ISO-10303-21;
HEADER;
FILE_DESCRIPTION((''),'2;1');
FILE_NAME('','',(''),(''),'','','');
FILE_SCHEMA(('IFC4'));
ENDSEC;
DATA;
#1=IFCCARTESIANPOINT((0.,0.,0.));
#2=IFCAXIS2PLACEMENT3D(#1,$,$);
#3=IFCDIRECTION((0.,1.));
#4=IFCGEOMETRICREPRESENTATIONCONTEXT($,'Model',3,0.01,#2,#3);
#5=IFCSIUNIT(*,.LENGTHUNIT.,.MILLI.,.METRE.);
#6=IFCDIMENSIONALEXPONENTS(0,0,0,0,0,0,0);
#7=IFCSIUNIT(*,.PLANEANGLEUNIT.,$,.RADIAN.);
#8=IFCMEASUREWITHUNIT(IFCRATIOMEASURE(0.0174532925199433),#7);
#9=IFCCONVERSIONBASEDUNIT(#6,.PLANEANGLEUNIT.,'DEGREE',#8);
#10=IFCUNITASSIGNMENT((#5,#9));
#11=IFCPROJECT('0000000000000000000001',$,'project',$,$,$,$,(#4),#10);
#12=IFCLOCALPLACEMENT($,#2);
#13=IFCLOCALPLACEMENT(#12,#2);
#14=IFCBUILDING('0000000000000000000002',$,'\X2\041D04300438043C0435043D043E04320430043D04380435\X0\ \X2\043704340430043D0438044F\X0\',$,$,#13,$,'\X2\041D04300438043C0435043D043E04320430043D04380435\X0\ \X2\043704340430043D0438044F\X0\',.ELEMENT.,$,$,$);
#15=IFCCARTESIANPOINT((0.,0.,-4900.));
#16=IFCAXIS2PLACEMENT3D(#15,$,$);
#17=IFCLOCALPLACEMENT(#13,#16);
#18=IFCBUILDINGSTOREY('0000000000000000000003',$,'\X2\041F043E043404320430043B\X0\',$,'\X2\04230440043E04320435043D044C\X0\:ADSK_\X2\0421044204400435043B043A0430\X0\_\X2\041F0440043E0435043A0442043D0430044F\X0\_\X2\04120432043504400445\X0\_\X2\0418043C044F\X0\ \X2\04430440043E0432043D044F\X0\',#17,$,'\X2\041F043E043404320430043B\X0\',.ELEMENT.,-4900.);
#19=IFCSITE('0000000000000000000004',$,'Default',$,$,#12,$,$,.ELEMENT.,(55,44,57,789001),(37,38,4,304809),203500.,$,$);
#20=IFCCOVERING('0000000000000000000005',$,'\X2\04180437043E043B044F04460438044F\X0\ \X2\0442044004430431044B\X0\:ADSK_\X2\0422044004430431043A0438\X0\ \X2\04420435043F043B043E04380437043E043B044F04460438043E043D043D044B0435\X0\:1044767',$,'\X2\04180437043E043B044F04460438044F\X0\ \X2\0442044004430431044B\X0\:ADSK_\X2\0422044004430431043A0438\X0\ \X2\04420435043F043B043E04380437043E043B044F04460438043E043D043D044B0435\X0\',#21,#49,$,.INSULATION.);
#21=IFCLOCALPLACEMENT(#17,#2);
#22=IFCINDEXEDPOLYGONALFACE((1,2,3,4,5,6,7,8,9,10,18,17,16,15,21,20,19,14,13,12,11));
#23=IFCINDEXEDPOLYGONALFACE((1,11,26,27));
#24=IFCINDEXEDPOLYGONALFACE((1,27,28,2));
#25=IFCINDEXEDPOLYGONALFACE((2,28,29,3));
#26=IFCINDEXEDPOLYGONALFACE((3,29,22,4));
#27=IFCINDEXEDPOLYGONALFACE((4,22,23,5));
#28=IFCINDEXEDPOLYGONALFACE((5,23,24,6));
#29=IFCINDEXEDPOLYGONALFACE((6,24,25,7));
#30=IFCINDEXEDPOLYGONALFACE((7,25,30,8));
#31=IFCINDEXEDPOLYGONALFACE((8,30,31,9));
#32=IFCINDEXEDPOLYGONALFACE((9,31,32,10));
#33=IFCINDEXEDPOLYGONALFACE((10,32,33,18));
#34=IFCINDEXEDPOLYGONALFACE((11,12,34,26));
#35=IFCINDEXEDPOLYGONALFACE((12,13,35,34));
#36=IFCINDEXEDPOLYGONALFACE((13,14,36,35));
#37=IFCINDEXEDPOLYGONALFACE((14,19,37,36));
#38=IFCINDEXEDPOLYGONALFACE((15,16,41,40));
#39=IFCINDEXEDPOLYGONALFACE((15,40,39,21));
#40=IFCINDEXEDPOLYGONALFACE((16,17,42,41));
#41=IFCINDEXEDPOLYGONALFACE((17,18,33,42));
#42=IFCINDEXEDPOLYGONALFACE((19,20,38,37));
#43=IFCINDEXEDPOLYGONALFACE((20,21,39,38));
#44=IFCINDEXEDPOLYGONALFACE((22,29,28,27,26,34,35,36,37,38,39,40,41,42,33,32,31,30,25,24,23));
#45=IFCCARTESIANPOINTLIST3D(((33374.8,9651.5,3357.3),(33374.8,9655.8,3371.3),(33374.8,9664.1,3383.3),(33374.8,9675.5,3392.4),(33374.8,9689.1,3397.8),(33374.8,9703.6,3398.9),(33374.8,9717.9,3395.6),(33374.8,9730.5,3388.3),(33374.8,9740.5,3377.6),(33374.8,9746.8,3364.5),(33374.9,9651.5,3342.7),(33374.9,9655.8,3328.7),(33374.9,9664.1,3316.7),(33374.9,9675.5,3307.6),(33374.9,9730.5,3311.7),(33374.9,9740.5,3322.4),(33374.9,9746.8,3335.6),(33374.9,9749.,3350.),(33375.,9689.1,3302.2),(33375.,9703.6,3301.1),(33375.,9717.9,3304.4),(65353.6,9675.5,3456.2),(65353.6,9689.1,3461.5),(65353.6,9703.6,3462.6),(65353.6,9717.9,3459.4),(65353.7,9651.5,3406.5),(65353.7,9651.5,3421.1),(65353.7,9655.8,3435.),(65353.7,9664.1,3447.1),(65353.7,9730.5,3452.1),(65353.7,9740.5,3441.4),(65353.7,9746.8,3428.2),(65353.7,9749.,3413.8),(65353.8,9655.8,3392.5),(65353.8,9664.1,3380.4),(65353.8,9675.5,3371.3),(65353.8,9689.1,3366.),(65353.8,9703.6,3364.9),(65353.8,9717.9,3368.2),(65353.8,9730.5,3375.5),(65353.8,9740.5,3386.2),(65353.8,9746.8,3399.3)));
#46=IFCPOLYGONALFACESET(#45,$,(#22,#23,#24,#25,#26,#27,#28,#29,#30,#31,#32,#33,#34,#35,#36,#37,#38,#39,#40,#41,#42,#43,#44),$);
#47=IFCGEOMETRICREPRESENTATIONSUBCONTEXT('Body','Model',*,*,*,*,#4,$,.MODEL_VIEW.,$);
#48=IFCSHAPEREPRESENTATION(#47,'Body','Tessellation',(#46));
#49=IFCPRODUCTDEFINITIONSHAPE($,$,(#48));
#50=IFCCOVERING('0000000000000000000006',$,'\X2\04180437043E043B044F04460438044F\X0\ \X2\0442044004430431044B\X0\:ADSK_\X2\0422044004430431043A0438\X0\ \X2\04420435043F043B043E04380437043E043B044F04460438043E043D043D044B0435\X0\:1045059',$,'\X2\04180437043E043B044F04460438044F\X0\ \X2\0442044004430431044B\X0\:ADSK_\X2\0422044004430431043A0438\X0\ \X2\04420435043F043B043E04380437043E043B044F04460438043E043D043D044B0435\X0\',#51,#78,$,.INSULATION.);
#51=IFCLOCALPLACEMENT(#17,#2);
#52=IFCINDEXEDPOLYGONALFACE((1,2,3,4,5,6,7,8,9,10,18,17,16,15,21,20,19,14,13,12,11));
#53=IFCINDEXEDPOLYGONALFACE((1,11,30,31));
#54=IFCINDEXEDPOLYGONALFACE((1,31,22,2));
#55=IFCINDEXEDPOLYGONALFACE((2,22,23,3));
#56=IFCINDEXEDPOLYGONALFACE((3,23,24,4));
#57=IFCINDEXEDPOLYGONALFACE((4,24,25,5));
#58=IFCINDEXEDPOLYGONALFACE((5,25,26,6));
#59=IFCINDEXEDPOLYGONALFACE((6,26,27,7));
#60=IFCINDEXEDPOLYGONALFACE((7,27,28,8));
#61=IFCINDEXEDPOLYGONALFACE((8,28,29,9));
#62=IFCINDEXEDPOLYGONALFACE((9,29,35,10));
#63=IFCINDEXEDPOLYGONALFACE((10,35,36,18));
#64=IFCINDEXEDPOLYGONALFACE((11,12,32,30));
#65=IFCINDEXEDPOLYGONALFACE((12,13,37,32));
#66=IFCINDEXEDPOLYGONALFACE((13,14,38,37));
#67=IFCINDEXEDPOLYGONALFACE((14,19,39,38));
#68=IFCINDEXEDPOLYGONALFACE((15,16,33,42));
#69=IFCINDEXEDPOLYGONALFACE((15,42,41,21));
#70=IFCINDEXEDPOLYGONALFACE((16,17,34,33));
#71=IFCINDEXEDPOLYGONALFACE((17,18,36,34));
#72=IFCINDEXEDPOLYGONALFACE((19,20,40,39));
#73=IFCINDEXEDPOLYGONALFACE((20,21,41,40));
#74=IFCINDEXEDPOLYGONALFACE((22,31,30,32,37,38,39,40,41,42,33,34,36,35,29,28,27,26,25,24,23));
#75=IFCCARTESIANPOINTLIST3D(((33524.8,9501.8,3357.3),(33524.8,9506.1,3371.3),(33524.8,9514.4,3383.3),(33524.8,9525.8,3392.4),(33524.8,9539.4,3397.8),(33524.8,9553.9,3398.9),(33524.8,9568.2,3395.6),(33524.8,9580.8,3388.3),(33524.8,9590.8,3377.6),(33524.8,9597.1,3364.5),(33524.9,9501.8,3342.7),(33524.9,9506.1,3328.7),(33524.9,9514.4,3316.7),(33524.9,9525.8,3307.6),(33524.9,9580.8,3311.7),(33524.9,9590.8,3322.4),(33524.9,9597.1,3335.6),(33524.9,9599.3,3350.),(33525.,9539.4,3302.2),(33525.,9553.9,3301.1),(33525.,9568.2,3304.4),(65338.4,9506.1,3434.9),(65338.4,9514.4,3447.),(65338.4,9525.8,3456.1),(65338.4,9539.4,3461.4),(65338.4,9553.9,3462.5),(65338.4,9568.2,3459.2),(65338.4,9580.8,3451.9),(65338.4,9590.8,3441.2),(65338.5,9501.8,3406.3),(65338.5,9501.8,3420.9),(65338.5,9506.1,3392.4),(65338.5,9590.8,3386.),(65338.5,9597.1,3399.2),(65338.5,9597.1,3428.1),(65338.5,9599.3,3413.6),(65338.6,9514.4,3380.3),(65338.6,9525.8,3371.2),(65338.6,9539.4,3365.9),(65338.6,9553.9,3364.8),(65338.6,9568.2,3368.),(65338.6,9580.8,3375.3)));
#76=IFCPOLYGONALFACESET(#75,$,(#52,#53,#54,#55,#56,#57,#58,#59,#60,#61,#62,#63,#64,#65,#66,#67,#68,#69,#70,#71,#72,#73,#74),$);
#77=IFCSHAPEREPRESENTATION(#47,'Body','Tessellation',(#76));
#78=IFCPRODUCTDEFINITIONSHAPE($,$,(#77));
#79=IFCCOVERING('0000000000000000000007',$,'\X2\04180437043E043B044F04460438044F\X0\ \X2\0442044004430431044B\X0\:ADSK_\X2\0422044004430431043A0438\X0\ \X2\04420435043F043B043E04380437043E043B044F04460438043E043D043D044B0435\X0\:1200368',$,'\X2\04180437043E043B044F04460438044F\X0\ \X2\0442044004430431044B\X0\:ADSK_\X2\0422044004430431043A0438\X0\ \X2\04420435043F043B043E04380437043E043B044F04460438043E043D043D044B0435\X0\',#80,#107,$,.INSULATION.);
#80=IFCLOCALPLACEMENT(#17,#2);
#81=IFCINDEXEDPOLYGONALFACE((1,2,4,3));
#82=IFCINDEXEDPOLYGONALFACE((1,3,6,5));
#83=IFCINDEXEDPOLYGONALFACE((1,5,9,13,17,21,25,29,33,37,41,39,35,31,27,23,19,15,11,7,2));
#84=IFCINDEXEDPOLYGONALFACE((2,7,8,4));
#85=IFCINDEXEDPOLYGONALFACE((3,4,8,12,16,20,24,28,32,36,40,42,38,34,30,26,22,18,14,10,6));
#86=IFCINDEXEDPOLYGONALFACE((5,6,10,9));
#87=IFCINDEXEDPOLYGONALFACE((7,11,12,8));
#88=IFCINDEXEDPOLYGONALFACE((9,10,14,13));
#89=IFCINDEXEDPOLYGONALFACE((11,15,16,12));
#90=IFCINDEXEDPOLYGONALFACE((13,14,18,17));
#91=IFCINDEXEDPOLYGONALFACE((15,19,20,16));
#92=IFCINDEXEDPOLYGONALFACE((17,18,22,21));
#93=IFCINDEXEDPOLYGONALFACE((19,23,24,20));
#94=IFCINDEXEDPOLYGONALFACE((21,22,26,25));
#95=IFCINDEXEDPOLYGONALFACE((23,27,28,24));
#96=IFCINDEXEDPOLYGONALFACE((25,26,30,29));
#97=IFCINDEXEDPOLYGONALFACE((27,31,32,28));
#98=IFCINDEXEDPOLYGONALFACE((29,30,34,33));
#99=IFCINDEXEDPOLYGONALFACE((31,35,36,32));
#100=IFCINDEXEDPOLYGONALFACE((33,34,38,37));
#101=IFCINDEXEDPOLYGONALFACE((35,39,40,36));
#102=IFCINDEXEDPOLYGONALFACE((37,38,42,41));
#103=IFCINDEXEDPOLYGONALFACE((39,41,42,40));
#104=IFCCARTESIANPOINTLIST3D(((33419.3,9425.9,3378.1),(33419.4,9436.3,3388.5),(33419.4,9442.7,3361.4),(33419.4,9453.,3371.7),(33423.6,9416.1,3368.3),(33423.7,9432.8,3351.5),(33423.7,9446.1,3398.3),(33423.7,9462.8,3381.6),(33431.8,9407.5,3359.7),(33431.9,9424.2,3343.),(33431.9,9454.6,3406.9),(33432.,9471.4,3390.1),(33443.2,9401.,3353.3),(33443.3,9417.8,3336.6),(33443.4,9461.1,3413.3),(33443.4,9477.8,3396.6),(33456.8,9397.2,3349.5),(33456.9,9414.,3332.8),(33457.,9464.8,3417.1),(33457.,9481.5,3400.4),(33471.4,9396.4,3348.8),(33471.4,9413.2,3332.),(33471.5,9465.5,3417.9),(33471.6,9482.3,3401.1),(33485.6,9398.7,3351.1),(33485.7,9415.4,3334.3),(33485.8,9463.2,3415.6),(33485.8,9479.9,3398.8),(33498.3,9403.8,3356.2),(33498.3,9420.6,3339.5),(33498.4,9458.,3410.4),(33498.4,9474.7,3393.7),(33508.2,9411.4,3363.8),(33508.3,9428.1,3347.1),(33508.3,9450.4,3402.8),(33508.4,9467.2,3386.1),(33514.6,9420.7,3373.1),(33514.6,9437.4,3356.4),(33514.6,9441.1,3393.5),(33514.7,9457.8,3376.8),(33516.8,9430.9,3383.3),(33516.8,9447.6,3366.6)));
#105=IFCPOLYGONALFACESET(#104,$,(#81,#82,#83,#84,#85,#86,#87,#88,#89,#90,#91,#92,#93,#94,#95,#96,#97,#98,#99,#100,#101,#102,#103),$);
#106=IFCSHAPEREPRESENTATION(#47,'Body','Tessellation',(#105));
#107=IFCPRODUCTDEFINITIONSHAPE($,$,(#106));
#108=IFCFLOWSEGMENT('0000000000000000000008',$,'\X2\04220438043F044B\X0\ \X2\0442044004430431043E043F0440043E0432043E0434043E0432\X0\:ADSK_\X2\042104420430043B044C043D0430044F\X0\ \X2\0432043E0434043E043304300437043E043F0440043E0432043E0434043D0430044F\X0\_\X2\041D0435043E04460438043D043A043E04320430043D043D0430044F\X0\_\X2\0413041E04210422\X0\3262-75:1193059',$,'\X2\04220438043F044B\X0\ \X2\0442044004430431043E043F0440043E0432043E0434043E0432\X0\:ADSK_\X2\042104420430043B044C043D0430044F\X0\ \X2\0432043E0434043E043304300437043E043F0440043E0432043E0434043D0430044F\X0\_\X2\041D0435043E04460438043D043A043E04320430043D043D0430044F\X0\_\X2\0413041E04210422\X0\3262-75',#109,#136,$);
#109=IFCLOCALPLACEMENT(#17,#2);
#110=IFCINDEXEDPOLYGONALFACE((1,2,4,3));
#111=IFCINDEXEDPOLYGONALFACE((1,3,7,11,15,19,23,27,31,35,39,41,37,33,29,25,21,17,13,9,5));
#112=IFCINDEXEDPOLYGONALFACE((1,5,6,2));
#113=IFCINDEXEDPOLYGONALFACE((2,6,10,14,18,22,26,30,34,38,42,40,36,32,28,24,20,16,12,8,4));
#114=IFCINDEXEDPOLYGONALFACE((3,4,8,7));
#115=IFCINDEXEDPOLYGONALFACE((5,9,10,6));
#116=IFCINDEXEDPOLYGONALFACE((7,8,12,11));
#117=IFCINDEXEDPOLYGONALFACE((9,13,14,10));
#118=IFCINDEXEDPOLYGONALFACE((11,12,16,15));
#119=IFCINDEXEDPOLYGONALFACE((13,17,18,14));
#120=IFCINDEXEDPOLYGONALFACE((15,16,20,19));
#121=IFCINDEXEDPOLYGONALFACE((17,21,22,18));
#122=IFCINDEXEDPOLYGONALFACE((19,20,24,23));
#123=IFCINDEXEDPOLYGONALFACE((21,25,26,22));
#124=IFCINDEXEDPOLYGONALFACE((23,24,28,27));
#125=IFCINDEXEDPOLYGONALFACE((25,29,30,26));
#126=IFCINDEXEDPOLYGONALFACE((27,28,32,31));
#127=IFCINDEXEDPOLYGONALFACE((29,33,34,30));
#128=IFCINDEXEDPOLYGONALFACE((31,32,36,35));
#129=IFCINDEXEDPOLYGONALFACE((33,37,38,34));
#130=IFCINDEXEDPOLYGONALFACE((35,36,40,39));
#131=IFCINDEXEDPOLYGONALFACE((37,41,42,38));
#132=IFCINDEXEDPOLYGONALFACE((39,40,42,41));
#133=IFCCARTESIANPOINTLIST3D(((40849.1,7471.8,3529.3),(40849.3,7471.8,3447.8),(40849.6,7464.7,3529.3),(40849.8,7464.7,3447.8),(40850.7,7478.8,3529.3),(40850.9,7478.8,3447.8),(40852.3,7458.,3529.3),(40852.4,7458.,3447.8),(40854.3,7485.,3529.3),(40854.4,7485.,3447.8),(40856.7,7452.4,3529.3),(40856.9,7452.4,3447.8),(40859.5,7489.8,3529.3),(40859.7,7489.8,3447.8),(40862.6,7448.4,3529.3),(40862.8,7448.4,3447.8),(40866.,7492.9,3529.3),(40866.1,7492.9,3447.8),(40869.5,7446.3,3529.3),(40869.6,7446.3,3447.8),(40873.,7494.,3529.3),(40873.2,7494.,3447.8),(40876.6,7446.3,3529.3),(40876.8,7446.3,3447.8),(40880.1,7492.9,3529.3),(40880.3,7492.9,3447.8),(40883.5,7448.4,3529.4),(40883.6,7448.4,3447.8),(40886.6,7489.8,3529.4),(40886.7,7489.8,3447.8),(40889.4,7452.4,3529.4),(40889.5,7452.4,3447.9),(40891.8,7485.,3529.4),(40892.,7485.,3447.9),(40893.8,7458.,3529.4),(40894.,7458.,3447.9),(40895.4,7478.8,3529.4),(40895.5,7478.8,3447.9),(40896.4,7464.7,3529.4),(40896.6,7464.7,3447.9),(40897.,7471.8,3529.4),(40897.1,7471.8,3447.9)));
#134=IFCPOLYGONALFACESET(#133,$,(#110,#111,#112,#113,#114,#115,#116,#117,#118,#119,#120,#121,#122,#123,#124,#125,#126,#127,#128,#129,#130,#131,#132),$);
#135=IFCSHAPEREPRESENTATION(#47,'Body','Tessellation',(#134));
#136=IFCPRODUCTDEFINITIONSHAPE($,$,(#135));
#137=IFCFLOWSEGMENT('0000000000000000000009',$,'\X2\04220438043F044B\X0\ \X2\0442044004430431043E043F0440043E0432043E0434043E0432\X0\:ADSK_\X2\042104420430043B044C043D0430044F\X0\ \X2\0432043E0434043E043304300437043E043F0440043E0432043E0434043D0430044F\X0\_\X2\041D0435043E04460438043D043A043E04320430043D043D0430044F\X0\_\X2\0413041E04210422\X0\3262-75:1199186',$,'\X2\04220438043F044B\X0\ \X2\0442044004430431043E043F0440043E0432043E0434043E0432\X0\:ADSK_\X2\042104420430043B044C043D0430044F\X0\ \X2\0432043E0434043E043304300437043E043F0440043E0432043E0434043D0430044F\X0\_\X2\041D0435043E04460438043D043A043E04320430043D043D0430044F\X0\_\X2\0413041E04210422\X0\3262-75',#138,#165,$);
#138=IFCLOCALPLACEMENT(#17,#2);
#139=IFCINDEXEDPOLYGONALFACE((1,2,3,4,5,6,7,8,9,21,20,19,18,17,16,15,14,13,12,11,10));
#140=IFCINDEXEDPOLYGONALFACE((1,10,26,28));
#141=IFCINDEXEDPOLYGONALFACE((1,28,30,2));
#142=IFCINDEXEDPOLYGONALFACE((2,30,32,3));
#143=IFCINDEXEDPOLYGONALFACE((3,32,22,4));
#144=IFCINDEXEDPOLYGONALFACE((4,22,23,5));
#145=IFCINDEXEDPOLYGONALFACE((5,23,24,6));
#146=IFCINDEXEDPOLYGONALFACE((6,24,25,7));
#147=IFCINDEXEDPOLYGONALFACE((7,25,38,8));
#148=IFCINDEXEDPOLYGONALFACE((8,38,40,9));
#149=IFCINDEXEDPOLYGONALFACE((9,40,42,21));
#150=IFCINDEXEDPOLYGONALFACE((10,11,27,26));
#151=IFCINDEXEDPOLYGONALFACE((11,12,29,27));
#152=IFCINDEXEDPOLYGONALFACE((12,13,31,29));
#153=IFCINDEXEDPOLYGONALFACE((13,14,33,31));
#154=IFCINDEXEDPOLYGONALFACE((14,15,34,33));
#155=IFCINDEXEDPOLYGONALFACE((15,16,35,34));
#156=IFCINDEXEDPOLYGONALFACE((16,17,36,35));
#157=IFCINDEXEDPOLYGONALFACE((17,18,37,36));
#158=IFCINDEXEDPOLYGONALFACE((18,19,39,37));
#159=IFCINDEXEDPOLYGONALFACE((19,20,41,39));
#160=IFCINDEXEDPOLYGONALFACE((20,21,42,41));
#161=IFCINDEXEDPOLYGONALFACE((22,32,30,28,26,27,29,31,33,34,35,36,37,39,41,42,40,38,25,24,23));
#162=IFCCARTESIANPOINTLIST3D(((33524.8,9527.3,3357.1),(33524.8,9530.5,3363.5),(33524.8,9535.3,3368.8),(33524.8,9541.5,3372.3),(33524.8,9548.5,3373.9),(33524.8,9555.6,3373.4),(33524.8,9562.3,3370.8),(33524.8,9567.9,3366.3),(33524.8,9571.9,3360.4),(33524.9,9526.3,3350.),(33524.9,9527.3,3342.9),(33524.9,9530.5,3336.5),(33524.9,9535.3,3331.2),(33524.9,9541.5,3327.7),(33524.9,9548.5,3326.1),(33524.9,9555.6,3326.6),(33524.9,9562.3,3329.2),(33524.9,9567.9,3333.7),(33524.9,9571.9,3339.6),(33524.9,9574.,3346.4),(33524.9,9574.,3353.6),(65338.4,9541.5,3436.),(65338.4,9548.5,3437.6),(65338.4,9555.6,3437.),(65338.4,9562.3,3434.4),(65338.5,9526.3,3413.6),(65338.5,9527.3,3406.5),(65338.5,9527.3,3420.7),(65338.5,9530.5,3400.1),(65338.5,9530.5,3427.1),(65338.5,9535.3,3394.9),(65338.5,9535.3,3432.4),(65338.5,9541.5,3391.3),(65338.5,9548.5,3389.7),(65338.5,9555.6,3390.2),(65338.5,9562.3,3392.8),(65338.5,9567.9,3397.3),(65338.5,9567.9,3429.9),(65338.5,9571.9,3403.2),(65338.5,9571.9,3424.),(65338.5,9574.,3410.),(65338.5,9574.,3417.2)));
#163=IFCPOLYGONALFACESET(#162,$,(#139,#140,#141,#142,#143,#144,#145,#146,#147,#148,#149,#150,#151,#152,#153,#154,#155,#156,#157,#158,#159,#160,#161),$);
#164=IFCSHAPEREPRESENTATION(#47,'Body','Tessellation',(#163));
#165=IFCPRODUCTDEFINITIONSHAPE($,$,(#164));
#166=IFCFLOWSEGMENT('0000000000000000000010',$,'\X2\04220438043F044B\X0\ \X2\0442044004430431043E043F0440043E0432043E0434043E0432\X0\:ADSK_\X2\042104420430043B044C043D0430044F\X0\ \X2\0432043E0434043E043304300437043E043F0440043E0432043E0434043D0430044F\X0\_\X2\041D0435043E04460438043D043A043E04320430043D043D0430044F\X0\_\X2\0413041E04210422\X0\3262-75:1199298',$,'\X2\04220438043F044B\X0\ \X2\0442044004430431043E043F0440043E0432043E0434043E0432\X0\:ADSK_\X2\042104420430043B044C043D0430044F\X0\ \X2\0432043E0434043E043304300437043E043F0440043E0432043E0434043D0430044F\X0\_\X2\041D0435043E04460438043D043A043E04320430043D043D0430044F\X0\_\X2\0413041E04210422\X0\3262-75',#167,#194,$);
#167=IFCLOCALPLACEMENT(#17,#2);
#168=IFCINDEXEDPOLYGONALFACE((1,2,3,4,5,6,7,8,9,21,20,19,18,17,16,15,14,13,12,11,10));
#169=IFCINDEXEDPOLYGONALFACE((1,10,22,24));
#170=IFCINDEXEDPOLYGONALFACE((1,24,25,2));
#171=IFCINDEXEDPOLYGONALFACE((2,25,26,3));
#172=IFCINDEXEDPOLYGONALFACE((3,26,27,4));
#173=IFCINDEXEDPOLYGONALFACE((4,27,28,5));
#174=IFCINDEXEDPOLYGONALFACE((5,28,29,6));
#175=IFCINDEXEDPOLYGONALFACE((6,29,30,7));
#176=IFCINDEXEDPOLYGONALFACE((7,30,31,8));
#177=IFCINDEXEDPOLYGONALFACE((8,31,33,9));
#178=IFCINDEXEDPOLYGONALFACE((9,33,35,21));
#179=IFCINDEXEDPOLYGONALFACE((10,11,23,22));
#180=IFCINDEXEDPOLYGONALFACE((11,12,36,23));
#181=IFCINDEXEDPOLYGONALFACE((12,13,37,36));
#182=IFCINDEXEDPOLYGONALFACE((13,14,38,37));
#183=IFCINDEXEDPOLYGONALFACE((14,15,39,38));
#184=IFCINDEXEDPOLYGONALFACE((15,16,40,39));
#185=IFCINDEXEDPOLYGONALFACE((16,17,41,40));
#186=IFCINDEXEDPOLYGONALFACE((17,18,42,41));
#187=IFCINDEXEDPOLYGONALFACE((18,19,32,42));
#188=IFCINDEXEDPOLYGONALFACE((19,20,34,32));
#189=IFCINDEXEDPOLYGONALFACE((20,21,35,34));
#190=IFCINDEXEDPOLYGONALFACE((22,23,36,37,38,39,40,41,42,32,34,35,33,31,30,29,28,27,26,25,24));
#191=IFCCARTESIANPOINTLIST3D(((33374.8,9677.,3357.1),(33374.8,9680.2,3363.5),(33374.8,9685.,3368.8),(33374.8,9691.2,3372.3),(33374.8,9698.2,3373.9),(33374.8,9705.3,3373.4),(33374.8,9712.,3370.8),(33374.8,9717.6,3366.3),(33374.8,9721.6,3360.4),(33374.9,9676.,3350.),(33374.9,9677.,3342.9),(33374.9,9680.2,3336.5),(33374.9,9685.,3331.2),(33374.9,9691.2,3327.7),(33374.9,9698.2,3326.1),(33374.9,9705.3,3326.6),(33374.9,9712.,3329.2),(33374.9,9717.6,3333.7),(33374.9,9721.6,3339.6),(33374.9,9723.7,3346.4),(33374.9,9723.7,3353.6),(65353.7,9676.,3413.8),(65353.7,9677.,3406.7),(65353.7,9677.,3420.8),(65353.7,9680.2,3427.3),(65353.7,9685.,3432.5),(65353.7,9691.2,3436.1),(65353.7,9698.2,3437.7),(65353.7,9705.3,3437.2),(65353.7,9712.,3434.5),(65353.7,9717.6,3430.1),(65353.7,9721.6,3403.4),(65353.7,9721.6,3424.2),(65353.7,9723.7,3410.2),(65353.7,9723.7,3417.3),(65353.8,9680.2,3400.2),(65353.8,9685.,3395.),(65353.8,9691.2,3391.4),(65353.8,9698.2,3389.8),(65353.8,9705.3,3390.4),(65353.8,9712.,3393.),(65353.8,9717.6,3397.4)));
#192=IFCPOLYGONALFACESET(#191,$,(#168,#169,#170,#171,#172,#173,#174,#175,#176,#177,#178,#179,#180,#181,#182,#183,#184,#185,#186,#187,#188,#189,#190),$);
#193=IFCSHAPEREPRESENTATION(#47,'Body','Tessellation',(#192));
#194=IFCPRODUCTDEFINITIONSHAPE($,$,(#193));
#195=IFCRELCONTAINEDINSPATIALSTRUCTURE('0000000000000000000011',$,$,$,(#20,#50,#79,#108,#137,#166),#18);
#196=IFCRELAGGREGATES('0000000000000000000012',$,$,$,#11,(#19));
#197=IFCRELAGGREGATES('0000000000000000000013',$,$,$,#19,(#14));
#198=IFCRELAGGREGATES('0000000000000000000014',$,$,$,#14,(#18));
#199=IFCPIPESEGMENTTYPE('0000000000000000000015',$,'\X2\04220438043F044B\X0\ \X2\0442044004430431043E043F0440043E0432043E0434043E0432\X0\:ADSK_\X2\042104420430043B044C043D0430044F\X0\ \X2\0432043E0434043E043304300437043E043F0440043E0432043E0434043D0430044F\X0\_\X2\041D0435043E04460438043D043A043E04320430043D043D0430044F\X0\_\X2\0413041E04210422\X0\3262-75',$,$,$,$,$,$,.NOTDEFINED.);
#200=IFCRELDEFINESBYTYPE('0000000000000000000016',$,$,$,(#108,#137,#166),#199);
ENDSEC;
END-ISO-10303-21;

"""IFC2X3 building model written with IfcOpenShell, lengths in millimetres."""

from ifc_helpers import new_model, entity, si_unit, converted_unit, direction, frame, origin, origin_2d_with_axis, place, context, subcontext, project, spatial, circle, extrude, type_object, element, save


model = new_model("IFC2X3")

# Units and contexts
model_context = context("Model", 3, precision=0.01, world=origin(), true_north=direction((0.0, 1.0)))
body_context = subcontext(model_context, "Body", "Model", "MODEL_VIEW")
ifc_project = project(units=[si_unit("LENGTHUNIT", "METRE", prefix="MILLI"), converted_unit("PLANEANGLEUNIT", "DEGREE", entity("IfcRatioMeasure", 0.0174532925199433), si_unit("PLANEANGLEUNIT", "RADIAN"), dimensions=[0, 0, 0, 0, 0, 0, 0])], contexts=[model_context])

# Site, building, storey
site_placement = place(None, origin())
site = spatial("IfcSite", under=ifc_project, at=site_placement, Name="Default", CompositionType="ELEMENT", RefLatitude=(55, 44, 57, 789001), RefLongitude=(37, 38, 4, 304809), RefElevation=203500.0)
building_placement = place(site_placement, origin())
building = spatial("IfcBuilding", under=site, at=building_placement, Name="Наименование здания", LongName="Наименование здания", CompositionType="ELEMENT")
storey_placement = place(building_placement, frame((0.0, 0.0, -4900.0)))
storey = spatial("IfcBuildingStorey", under=building, at=storey_placement, Name="Подвал", ObjectType="Уровень:ADSK_Стрелка_Проектная_Вверх_Имя уровня", LongName="Подвал", CompositionType="ELEMENT", Elevation=-4900.0)

# Coverings
covering_1_placement = place(storey_placement, frame((33374.8, 9649.4, 3299.4)))
element("IfcCovering", 1, at=covering_1_placement, inside=storey, Name="Изоляция трубы:ADSK_Трубки теплоизоляционные:1044767", ObjectType="Изоляция трубы:ADSK_Трубки теплоизоляционные", PredefinedType="INSULATION", context=body_context, shape_type="SweptSolid", body=[
    extrude(circle(Radius=49.0, at=origin_2d_with_axis()), frame((0.1, 50.6, 50.6), z_axis=(0.999998, 0.0, 0.001994), x_axis=(0.0, 1.0, 0.0)), (0.0, 0.0, 1.0), 31978.9),
])
covering_2_placement = place(storey_placement, frame((33524.8, 9499.7, 3299.4)))
element("IfcCovering", 2, at=covering_2_placement, inside=storey, Name="Изоляция трубы:ADSK_Трубки теплоизоляционные:1045059", ObjectType="Изоляция трубы:ADSK_Трубки теплоизоляционные", PredefinedType="INSULATION", context=body_context, shape_type="SweptSolid", body=[
    extrude(circle(Radius=49.0, at=origin_2d_with_axis()), frame((0.1, 50.6, 50.6), z_axis=(0.999998, 0.0, 0.002), x_axis=(0.0, 1.0, 0.0)), (0.0, 0.0, 1.0), 31813.7),
])
covering_3_placement = place(storey_placement, frame((33417.2, 9394.8, 3330.3)))
element("IfcCovering", 3, at=covering_3_placement, inside=storey, Name="Изоляция трубы:ADSK_Трубки теплоизоляционные:1200368", ObjectType="Изоляция трубы:ADSK_Трубки теплоизоляционные", PredefinedType="INSULATION", context=body_context, shape_type="SweptSolid", body=[
    extrude(circle(Radius=49.0, at=origin_2d_with_axis()), frame((50.6, 53.0, 36.2), z_axis=(-0.001414, -0.707105, 0.707107), x_axis=(0.999998, -0.002, 0.0)), (0.0, 0.0, 1.0), 23.7),
])

# Flow segments
pipe_segment_type_1 = type_object("IfcPipeSegmentType", Name="Типы трубопроводов:ADSK_Стальная водогазопроводная_Неоцинкованная_ГОСТ3262-75", PredefinedType="NOTDEFINED")
flow_segment_1_placement = place(storey_placement, frame((40847.4, 7444.4, 3447.8)))
element("IfcFlowSegment", 4, at=flow_segment_1_placement, inside=storey, type_object=pipe_segment_type_1, Name="Типы трубопроводов:ADSK_Стальная водогазопроводная_Неоцинкованная_ГОСТ3262-75:1193059", ObjectType="Типы трубопроводов:ADSK_Стальная водогазопроводная_Неоцинкованная_ГОСТ3262-75", context=body_context, shape_type="SweptSolid", body=[
    extrude(circle(Radius=24.0, at=origin_2d_with_axis()), frame((25.8, 25.6, 0.1), z_axis=(-0.002, 0.0, 0.999998), x_axis=(0.0, 1.0, 0.0)), (0.0, 0.0, 1.0), 81.5),
])
flow_segment_2_placement = place(storey_placement, frame((33524.8, 9524.7, 3324.4)))
element("IfcFlowSegment", 5, at=flow_segment_2_placement, inside=storey, type_object=pipe_segment_type_1, Name="Типы трубопроводов:ADSK_Стальная водогазопроводная_Неоцинкованная_ГОСТ3262-75:1199186", ObjectType="Типы трубопроводов:ADSK_Стальная водогазопроводная_Неоцинкованная_ГОСТ3262-75", context=body_context, shape_type="SweptSolid", body=[
    extrude(circle(Radius=24.0, at=origin_2d_with_axis()), frame((0.1, 25.6, 25.6), z_axis=(0.999998, 0.0, 0.002), x_axis=(0.0, -1.0, 0.0)), (0.0, 0.0, 1.0), 31813.7),
])
flow_segment_3_placement = place(storey_placement, frame((33374.8, 9674.4, 3324.4)))
element("IfcFlowSegment", 6, at=flow_segment_3_placement, inside=storey, type_object=pipe_segment_type_1, Name="Типы трубопроводов:ADSK_Стальная водогазопроводная_Неоцинкованная_ГОСТ3262-75:1199298", ObjectType="Типы трубопроводов:ADSK_Стальная водогазопроводная_Неоцинкованная_ГОСТ3262-75", context=body_context, shape_type="SweptSolid", body=[
    extrude(circle(Radius=24.0, at=origin_2d_with_axis()), frame((0.1, 25.6, 25.6), z_axis=(0.999998, 0.0, 0.001994), x_axis=(0.0, -1.0, 0.0)), (0.0, 0.0, 1.0), 31978.9),
])

save(model, "model.ifc")
